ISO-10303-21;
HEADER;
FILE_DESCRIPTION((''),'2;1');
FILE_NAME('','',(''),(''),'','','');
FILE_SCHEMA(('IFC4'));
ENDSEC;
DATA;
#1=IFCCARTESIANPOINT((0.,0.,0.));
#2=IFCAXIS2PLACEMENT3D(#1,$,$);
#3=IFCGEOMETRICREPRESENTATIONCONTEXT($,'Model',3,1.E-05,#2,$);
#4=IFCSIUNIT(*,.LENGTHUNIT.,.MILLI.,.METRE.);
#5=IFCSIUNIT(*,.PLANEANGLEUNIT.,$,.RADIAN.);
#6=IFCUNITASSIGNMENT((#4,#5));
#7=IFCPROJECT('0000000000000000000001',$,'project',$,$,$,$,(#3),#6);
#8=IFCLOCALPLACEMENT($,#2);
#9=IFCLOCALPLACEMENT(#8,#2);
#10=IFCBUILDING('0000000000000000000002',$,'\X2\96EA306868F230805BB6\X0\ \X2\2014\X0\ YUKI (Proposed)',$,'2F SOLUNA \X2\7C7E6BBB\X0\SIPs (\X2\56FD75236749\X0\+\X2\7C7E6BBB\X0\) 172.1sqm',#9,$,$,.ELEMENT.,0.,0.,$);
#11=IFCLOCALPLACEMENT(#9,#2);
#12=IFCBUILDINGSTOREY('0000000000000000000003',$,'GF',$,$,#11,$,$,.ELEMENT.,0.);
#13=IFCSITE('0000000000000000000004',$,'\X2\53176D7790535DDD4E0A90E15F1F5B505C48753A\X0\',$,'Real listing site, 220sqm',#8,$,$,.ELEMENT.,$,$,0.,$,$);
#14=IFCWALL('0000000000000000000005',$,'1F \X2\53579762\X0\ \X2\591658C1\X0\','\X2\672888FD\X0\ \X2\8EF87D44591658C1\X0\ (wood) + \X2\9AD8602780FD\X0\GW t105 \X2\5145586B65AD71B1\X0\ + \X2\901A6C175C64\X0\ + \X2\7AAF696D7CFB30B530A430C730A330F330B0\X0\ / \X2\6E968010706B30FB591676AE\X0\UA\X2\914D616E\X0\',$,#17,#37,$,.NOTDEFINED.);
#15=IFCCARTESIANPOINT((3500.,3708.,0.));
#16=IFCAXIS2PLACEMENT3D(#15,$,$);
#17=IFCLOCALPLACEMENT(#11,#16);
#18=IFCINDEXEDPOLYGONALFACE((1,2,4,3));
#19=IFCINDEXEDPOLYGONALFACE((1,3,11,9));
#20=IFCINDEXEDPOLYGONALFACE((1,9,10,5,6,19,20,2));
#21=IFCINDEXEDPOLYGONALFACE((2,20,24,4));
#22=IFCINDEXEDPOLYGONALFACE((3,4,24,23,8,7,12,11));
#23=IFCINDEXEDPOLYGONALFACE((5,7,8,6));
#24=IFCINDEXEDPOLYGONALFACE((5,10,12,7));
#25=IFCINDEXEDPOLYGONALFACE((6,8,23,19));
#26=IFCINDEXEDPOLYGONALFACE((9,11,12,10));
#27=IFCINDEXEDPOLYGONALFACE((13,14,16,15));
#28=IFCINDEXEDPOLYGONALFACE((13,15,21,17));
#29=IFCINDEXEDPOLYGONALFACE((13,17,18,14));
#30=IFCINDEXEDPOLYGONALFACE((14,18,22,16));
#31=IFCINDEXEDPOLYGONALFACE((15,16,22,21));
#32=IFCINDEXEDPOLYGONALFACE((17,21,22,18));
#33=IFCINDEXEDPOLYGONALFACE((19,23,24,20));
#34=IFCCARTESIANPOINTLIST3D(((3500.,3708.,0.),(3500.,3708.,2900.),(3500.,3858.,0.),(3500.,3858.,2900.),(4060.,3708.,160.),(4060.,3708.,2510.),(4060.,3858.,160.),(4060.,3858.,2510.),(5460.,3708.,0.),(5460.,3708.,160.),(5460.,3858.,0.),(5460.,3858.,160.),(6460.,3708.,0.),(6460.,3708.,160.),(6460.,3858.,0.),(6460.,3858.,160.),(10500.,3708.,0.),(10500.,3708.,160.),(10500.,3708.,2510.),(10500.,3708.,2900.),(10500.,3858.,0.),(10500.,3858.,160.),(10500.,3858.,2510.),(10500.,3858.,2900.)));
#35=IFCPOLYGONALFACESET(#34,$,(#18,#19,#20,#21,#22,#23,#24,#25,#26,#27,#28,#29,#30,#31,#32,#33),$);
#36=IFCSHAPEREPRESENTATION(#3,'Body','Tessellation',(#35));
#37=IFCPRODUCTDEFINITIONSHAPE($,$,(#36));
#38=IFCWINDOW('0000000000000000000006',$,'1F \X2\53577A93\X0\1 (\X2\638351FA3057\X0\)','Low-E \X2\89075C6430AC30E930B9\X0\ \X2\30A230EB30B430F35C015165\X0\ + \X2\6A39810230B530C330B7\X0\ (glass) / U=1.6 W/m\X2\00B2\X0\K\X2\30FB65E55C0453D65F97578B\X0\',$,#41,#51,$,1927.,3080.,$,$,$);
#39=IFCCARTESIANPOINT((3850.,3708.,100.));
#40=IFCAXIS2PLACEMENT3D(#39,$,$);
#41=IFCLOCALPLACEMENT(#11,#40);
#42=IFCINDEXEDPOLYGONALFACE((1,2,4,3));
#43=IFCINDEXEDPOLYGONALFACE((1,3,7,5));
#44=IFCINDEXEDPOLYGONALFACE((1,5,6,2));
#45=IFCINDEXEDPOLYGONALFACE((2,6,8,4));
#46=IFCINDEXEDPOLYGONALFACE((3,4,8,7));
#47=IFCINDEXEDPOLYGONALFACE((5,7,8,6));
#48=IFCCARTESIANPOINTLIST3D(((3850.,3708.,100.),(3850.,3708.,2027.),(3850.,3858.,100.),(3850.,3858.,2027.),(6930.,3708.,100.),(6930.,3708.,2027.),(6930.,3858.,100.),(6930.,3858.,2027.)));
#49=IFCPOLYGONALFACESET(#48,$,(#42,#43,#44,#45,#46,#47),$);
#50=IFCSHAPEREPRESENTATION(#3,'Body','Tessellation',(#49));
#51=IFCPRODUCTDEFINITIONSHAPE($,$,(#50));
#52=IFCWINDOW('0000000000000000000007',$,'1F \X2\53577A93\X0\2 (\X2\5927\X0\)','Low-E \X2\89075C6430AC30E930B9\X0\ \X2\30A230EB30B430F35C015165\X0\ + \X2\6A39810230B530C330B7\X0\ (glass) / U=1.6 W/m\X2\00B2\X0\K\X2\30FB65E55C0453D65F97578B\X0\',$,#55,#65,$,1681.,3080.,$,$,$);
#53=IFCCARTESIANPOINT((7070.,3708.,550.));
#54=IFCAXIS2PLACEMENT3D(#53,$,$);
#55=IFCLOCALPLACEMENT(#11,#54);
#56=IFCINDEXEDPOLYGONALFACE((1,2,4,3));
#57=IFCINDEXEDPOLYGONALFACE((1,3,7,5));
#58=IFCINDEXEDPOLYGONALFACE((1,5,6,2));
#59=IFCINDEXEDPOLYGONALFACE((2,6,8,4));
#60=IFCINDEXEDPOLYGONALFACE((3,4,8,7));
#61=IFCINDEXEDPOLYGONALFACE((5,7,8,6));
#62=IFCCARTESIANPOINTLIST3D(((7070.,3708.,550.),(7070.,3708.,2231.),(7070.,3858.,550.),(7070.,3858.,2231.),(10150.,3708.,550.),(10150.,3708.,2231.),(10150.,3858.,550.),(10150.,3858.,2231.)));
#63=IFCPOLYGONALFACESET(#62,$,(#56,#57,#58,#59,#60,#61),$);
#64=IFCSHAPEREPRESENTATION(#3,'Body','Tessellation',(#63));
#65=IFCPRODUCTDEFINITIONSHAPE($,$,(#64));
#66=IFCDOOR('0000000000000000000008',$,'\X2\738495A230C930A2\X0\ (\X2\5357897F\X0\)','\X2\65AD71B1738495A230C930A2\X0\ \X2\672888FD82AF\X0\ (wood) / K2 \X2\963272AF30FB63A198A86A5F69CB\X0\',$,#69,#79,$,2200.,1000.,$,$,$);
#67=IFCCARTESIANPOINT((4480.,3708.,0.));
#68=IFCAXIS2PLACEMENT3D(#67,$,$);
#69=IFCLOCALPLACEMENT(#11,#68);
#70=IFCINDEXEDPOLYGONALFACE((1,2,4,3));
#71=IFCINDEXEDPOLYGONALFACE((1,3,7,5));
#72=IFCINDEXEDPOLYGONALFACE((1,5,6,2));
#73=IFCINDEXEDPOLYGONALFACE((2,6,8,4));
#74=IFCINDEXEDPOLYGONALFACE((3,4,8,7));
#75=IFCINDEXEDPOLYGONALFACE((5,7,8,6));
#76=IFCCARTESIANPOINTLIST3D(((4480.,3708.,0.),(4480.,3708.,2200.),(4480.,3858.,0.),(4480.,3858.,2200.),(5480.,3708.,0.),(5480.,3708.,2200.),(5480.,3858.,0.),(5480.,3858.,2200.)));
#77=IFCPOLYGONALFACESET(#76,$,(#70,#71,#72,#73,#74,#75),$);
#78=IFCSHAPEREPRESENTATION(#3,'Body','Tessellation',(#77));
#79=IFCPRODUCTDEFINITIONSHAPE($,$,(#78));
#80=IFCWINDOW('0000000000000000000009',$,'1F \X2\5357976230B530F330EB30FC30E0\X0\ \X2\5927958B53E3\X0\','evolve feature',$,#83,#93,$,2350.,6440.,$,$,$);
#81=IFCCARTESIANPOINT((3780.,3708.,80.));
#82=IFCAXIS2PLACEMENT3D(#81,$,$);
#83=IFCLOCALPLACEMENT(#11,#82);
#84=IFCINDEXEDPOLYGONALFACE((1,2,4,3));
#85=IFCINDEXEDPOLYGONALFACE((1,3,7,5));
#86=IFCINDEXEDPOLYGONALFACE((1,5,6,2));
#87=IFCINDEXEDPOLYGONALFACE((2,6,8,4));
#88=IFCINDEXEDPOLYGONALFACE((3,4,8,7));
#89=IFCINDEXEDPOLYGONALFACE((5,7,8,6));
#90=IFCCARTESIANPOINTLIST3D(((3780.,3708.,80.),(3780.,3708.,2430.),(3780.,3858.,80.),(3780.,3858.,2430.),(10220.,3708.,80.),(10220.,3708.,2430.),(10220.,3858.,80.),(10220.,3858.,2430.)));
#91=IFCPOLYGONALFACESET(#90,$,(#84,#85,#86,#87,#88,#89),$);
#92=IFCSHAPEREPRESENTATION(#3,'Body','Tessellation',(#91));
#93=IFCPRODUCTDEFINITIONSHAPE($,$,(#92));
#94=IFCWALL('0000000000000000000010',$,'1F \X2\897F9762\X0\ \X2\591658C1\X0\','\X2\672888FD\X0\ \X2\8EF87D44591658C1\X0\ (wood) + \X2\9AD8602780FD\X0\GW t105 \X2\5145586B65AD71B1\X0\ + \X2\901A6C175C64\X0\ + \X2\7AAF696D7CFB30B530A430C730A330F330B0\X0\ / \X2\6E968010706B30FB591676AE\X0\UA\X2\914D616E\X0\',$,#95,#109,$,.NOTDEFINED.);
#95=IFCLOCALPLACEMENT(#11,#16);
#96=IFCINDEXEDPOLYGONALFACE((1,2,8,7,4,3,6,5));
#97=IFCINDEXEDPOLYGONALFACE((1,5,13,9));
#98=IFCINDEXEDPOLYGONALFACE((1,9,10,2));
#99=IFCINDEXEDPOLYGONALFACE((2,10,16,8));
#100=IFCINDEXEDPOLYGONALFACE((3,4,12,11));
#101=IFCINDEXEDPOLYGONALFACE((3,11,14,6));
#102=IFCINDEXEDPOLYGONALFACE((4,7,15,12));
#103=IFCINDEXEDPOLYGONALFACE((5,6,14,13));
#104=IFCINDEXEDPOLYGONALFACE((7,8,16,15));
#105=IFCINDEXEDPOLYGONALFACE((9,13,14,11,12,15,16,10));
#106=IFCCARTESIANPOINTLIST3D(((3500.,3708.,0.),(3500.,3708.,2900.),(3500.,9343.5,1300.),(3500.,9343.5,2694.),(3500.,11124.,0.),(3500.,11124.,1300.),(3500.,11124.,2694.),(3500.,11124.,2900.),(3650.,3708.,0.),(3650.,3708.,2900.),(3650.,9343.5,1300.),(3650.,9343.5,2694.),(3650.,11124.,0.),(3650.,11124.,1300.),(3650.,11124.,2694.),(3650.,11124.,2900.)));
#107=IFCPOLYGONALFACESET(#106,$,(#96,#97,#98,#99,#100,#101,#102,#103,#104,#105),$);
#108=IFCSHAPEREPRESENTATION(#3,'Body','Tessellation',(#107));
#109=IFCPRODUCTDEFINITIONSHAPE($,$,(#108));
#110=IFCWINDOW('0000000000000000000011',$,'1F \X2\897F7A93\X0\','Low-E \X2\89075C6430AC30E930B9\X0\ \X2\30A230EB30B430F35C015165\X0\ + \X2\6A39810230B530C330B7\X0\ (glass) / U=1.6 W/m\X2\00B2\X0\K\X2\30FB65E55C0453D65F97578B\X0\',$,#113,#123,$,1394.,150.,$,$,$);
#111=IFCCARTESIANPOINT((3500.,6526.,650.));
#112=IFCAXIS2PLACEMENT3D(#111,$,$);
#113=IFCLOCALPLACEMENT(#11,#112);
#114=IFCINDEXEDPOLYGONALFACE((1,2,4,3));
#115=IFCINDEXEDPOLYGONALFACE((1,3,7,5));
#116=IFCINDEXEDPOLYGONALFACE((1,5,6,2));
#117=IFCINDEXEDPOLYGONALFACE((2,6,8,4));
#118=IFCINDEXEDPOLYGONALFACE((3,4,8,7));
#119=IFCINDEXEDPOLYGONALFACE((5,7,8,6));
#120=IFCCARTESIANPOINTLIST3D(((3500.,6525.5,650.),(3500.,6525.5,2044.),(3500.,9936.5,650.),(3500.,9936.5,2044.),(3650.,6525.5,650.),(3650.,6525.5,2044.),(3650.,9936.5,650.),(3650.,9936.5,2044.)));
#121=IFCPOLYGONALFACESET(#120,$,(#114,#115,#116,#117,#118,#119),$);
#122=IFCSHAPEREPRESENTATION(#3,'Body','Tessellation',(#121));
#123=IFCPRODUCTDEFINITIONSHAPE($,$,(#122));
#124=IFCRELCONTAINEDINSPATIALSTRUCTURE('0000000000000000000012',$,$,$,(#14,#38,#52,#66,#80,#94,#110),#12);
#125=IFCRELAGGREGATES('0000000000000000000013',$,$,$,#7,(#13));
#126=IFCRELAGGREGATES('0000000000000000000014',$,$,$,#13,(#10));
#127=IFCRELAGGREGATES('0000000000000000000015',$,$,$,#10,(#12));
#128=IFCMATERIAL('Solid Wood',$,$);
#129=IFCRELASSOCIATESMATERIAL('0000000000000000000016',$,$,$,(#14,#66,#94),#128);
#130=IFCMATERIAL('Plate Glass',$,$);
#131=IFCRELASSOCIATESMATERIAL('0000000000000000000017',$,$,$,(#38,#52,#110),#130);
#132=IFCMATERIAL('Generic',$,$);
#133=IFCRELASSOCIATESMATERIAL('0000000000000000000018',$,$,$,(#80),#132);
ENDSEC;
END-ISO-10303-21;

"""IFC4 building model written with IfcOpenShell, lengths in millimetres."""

from ifc_helpers import new_model, si_unit, frame, frame_2d, origin, place, context, project, spatial, rectangle, extrude, material, element, fill, save


model = new_model("IFC4")

# Units and contexts
model_context = context("Model", 3, precision=1e-05, world=origin())
ifc_project = project(units=[si_unit("LENGTHUNIT", "METRE", prefix="MILLI"), si_unit("PLANEANGLEUNIT", "RADIAN")], contexts=[model_context])

# Site, building, storey
site_placement = place(None, origin())
site = spatial("IfcSite", under=ifc_project, at=site_placement, Name="北海道川上郡弟子屈町", ObjectType="Real listing site, 220sqm", CompositionType="ELEMENT", RefElevation=0.0)
building_placement = place(site_placement, origin())
building = spatial("IfcBuilding", under=site, at=building_placement, Name="雪と棲む家 — YUKI (Proposed)", ObjectType="2F SOLUNA 籾殻SIPs (国産杉+籾殻) 172.1sqm", CompositionType="ELEMENT", ElevationOfRefHeight=0.0, ElevationOfTerrain=0.0)
storey_placement = place(building_placement, origin())
storey = spatial("IfcBuildingStorey", under=building, at=storey_placement, Name="GF", CompositionType="ELEMENT", Elevation=0.0)

# Shared definitions
ifc_material_1 = material(Name="Solid Wood")
ifc_material_2 = material(Name="Generic")

# Wall, openings, windows, door
wall_1_placement = place(storey_placement, frame((3500.0, 3708.0, 0.0)))
wall_1 = element("IfcWall", 1, at=wall_1_placement, inside=storey, material=ifc_material_1, Name="1F 南面 外壁", Description="木製 軸組外壁 (wood) + 高性能GW t105 充填断熱 + 通気層 + 窯業系サイディング / 準耐火・外皮UA配慮", PredefinedType="NOTDEFINED", context=model_context, shape_type="SweptSolid", body=[
    extrude(rectangle(XDim=7000.0, YDim=150.0, at=frame_2d((3500.0, 75.0))), frame((3500.0, 3708.0, 0.0)), (0.0, 0.0, 1.0), 2900.0),
])
opening_1_placement = place(storey_placement, frame((3850.0, 3708.0, 100.0)))
opening_1 = element("IfcOpeningElement", 2, at=opening_1_placement, cuts=wall_1, PredefinedType="NOTDEFINED", context=model_context, shape_type="SweptSolid", body=[
    extrude(rectangle(XDim=3080.0, YDim=150.0, at=frame_2d((1540.0, 75.0))), frame((3850.0, 3708.0, 100.0)), (0.0, 0.0, 1.0), 1927.0),
])
opening_2_placement = place(storey_placement, frame((7070.0, 3708.0, 550.0)))
opening_2 = element("IfcOpeningElement", 3, at=opening_2_placement, cuts=wall_1, PredefinedType="NOTDEFINED", context=model_context, shape_type="SweptSolid", body=[
    extrude(rectangle(XDim=3080.0, YDim=150.0, at=frame_2d((1540.0, 75.0))), frame((7070.0, 3708.0, 550.0)), (0.0, 0.0, 1.0), 1681.0),
])
opening_3_placement = place(storey_placement, frame((4480.0, 3708.0, 0.0)))
opening_3 = element("IfcOpeningElement", 4, at=opening_3_placement, cuts=wall_1, PredefinedType="NOTDEFINED", context=model_context, shape_type="SweptSolid", body=[
    extrude(rectangle(XDim=1000.0, YDim=150.0, at=frame_2d((500.0, 75.0))), frame((4480.0, 3708.0, 0.0)), (0.0, 0.0, 1.0), 2200.0),
])
opening_4_placement = place(storey_placement, frame((3780.0, 3708.0, 80.0)))
opening_4 = element("IfcOpeningElement", 5, at=opening_4_placement, cuts=wall_1, PredefinedType="NOTDEFINED", context=model_context, shape_type="SweptSolid", body=[
    extrude(rectangle(XDim=6440.0, YDim=150.0, at=frame_2d((3220.0, 75.0))), frame((3780.0, 3708.0, 80.0)), (0.0, 0.0, 1.0), 2350.0),
])
ifc_material_3 = material(Name="Plate Glass")
window_1_placement = place(storey_placement, frame((3850.0, 3708.0, 100.0)))
window_1 = element("IfcWindow", 6, at=window_1_placement, inside=storey, material=ifc_material_3, Name="1F 南窓1 (掃出し)", Description="Low-E 複層ガラス アルゴン封入 + 樹脂サッシ (glass) / U=1.6 W/m²K・日射取得型", OverallHeight=1927.0, OverallWidth=3080.0, context=model_context, shape_type="SweptSolid", body=[
    extrude(rectangle(XDim=3080.0, YDim=150.0, at=frame_2d((1540.0, 75.0))), frame((3850.0, 3708.0, 100.0)), (0.0, 0.0, 1.0), 1927.0),
])
fill(opening_1, window_1)
window_2_placement = place(storey_placement, frame((7070.0, 3708.0, 550.0)))
window_2 = element("IfcWindow", 7, at=window_2_placement, inside=storey, material=ifc_material_3, Name="1F 南窓2 (大)", Description="Low-E 複層ガラス アルゴン封入 + 樹脂サッシ (glass) / U=1.6 W/m²K・日射取得型", OverallHeight=1681.0, OverallWidth=3080.0, context=model_context, shape_type="SweptSolid", body=[
    extrude(rectangle(XDim=3080.0, YDim=150.0, at=frame_2d((1540.0, 75.0))), frame((7070.0, 3708.0, 550.0)), (0.0, 0.0, 1.0), 1681.0),
])
fill(opening_2, window_2)
door_placement = place(storey_placement, frame((4480.0, 3708.0, 0.0)))
door = element("IfcDoor", 8, at=door_placement, inside=storey, material=ifc_material_1, Name="玄関ドア (南西)", Description="断熱玄関ドア 木製芯 (wood) / K2 防犯・採風機構", OverallHeight=2200.0, OverallWidth=1000.0, context=model_context, shape_type="SweptSolid", body=[
    extrude(rectangle(XDim=1000.0, YDim=150.0, at=frame_2d((500.0, 75.0))), frame((4480.0, 3708.0, 0.0)), (0.0, 0.0, 1.0), 2200.0),
])
fill(opening_3, door)
window_3_placement = place(storey_placement, frame((3780.0, 3708.0, 80.0)))
window_3 = element("IfcWindow", 9, at=window_3_placement, inside=storey, material=ifc_material_2, Name="1F 南面サンルーム 大開口", Description="evolve feature", OverallHeight=2350.0, OverallWidth=6440.0, context=model_context, shape_type="SweptSolid", body=[
    extrude(rectangle(XDim=6440.0, YDim=150.0, at=frame_2d((3220.0, 75.0))), frame((3780.0, 3708.0, 80.0)), (0.0, 0.0, 1.0), 2350.0),
])
fill(opening_4, window_3)

# Wall, opening, window
wall_2_placement = place(storey_placement, frame((3500.0, 3708.0, 0.0)))
wall_2 = element("IfcWall", 10, at=wall_2_placement, inside=storey, material=ifc_material_1, Name="1F 西面 外壁", Description="木製 軸組外壁 (wood) + 高性能GW t105 充填断熱 + 通気層 + 窯業系サイディング / 準耐火・外皮UA配慮", PredefinedType="NOTDEFINED", context=model_context, shape_type="SweptSolid", body=[
    extrude(rectangle(XDim=150.0, YDim=7416.0, at=frame_2d((75.0, 3708.0))), frame((3500.0, 3708.0, 0.0)), (0.0, 0.0, 1.0), 2900.0),
])
opening_5_placement = place(storey_placement, frame((3500.0, 6526.0, 650.0)))
opening_5 = element("IfcOpeningElement", 11, at=opening_5_placement, cuts=wall_2, PredefinedType="NOTDEFINED", context=model_context, shape_type="SweptSolid", body=[
    extrude(rectangle(XDim=150.0, YDim=3411.0, at=frame_2d((75.0, 1705.0))), frame((3500.0, 6526.0, 650.0)), (0.0, 0.0, 1.0), 1394.0),
])
window_4_placement = place(storey_placement, frame((3500.0, 6526.0, 650.0)))
window_4 = element("IfcWindow", 12, at=window_4_placement, inside=storey, material=ifc_material_3, Name="1F 西窓", Description="Low-E 複層ガラス アルゴン封入 + 樹脂サッシ (glass) / U=1.6 W/m²K・日射取得型", OverallHeight=1394.0, OverallWidth=150.0, context=model_context, shape_type="SweptSolid", body=[
    extrude(rectangle(XDim=150.0, YDim=3411.0, at=frame_2d((75.0, 1705.0))), frame((3500.0, 6526.0, 650.0)), (0.0, 0.0, 1.0), 1394.0),
])
fill(opening_5, window_4)

save(model, "model.ifc")
